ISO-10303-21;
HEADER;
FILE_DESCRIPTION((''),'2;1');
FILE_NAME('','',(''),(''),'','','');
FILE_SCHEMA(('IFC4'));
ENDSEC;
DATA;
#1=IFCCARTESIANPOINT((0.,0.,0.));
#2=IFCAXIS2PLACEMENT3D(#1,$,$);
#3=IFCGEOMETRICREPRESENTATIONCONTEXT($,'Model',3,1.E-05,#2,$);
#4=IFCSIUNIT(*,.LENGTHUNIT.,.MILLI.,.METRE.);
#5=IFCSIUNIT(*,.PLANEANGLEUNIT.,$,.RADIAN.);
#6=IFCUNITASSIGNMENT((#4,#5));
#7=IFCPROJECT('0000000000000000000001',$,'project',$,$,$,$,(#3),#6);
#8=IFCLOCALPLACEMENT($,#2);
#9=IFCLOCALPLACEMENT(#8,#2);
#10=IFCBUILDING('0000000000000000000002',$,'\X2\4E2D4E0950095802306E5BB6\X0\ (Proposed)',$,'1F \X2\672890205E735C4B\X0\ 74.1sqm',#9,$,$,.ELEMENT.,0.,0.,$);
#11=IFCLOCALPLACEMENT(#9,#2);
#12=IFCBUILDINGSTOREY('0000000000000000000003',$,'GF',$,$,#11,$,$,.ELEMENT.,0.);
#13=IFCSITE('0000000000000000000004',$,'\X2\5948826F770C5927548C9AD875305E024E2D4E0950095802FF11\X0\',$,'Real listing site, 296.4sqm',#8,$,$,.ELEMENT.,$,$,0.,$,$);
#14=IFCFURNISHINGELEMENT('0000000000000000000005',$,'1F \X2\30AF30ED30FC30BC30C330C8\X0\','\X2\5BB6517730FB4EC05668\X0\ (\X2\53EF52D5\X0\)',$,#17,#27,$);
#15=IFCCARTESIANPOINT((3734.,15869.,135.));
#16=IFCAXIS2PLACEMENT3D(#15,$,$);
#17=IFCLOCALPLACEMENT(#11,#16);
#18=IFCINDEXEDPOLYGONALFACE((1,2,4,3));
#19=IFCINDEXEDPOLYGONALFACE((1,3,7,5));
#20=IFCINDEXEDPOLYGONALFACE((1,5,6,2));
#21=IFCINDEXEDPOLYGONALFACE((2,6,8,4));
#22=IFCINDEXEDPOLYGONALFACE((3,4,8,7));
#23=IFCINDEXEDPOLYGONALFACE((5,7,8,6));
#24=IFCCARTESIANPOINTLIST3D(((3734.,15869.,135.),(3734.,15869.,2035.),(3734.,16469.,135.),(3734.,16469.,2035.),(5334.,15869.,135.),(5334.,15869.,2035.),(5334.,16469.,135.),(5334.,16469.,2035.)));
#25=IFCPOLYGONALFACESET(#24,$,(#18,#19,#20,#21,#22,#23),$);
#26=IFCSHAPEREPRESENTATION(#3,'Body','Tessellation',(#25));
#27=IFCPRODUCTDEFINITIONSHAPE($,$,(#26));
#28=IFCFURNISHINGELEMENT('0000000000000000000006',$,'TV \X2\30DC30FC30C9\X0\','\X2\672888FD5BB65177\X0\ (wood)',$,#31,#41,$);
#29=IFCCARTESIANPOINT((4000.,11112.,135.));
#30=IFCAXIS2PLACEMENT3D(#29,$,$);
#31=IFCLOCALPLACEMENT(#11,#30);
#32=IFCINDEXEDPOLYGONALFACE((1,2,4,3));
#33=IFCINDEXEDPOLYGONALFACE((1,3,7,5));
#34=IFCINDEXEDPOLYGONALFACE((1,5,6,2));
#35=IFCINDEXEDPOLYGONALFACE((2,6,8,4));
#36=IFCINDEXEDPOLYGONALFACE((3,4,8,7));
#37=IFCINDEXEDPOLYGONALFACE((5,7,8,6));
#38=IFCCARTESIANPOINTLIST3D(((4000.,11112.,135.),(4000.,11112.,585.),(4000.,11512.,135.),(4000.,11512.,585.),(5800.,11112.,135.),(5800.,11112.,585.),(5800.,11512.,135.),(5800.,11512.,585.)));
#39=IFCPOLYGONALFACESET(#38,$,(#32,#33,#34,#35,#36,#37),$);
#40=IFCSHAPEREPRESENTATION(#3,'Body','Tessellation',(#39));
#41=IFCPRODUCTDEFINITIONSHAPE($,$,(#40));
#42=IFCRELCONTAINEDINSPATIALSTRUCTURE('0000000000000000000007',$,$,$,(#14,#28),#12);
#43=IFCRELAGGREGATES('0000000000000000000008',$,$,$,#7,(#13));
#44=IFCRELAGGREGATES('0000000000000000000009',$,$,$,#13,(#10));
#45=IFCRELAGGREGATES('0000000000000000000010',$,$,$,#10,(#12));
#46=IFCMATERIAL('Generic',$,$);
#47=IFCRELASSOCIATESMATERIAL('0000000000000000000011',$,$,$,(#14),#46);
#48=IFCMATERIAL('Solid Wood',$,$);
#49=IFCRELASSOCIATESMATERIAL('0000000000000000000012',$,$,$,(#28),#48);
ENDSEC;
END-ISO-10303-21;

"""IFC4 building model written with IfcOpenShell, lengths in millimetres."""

from ifc_helpers import new_model, si_unit, frame, frame_2d, origin, place, context, project, spatial, rectangle, extrude, material, element, save


model = new_model("IFC4")

# Units and contexts
model_context = context("Model", 3, precision=1e-05, world=origin())
ifc_project = project(units=[si_unit("LENGTHUNIT", "METRE", prefix="MILLI"), si_unit("PLANEANGLEUNIT", "RADIAN")], contexts=[model_context])

# Site, building, storey
site_placement = place(None, origin())
site = spatial("IfcSite", under=ifc_project, at=site_placement, Name="奈良県大和高田市中三倉堂１", ObjectType="Real listing site, 296.4sqm", CompositionType="ELEMENT", RefElevation=0.0)
building_placement = place(site_placement, origin())
building = spatial("IfcBuilding", under=site, at=building_placement, Name="中三倉堂の家 (Proposed)", ObjectType="1F 木造平屋 74.1sqm", CompositionType="ELEMENT", ElevationOfRefHeight=0.0, ElevationOfTerrain=0.0)
storey_placement = place(building_placement, origin())
storey = spatial("IfcBuildingStorey", under=building, at=storey_placement, Name="GF", CompositionType="ELEMENT", Elevation=0.0)

# Shared definitions
ifc_material_1 = material(Name="Solid Wood")

# Shared definitions
ifc_material_2 = material(Name="Generic")

# Furnishing elements
furnishing_1_placement = place(storey_placement, frame((3734.0, 15869.0, 135.0)))
element("IfcFurnishingElement", 1, at=furnishing_1_placement, inside=storey, material=ifc_material_2, Name="1F クローゼット", Description="家具・什器 (可動)", context=model_context, shape_type="SweptSolid", body=[
    extrude(rectangle(XDim=1600.0, YDim=600.0, at=frame_2d((800.0, 300.0))), frame((3734.0, 15869.0, 135.0)), (0.0, 0.0, 1.0), 1900.0),
])
furnishing_2_placement = place(storey_placement, frame((4000.0, 11112.0, 135.0)))
element("IfcFurnishingElement", 2, at=furnishing_2_placement, inside=storey, material=ifc_material_1, Name="TV ボード", Description="木製家具 (wood)", context=model_context, shape_type="SweptSolid", body=[
    extrude(rectangle(XDim=1800.0, YDim=400.0, at=frame_2d((900.0, 200.0))), frame((4000.0, 11112.0, 135.0)), (0.0, 0.0, 1.0), 450.0),
])

save(model, "model.ifc")
